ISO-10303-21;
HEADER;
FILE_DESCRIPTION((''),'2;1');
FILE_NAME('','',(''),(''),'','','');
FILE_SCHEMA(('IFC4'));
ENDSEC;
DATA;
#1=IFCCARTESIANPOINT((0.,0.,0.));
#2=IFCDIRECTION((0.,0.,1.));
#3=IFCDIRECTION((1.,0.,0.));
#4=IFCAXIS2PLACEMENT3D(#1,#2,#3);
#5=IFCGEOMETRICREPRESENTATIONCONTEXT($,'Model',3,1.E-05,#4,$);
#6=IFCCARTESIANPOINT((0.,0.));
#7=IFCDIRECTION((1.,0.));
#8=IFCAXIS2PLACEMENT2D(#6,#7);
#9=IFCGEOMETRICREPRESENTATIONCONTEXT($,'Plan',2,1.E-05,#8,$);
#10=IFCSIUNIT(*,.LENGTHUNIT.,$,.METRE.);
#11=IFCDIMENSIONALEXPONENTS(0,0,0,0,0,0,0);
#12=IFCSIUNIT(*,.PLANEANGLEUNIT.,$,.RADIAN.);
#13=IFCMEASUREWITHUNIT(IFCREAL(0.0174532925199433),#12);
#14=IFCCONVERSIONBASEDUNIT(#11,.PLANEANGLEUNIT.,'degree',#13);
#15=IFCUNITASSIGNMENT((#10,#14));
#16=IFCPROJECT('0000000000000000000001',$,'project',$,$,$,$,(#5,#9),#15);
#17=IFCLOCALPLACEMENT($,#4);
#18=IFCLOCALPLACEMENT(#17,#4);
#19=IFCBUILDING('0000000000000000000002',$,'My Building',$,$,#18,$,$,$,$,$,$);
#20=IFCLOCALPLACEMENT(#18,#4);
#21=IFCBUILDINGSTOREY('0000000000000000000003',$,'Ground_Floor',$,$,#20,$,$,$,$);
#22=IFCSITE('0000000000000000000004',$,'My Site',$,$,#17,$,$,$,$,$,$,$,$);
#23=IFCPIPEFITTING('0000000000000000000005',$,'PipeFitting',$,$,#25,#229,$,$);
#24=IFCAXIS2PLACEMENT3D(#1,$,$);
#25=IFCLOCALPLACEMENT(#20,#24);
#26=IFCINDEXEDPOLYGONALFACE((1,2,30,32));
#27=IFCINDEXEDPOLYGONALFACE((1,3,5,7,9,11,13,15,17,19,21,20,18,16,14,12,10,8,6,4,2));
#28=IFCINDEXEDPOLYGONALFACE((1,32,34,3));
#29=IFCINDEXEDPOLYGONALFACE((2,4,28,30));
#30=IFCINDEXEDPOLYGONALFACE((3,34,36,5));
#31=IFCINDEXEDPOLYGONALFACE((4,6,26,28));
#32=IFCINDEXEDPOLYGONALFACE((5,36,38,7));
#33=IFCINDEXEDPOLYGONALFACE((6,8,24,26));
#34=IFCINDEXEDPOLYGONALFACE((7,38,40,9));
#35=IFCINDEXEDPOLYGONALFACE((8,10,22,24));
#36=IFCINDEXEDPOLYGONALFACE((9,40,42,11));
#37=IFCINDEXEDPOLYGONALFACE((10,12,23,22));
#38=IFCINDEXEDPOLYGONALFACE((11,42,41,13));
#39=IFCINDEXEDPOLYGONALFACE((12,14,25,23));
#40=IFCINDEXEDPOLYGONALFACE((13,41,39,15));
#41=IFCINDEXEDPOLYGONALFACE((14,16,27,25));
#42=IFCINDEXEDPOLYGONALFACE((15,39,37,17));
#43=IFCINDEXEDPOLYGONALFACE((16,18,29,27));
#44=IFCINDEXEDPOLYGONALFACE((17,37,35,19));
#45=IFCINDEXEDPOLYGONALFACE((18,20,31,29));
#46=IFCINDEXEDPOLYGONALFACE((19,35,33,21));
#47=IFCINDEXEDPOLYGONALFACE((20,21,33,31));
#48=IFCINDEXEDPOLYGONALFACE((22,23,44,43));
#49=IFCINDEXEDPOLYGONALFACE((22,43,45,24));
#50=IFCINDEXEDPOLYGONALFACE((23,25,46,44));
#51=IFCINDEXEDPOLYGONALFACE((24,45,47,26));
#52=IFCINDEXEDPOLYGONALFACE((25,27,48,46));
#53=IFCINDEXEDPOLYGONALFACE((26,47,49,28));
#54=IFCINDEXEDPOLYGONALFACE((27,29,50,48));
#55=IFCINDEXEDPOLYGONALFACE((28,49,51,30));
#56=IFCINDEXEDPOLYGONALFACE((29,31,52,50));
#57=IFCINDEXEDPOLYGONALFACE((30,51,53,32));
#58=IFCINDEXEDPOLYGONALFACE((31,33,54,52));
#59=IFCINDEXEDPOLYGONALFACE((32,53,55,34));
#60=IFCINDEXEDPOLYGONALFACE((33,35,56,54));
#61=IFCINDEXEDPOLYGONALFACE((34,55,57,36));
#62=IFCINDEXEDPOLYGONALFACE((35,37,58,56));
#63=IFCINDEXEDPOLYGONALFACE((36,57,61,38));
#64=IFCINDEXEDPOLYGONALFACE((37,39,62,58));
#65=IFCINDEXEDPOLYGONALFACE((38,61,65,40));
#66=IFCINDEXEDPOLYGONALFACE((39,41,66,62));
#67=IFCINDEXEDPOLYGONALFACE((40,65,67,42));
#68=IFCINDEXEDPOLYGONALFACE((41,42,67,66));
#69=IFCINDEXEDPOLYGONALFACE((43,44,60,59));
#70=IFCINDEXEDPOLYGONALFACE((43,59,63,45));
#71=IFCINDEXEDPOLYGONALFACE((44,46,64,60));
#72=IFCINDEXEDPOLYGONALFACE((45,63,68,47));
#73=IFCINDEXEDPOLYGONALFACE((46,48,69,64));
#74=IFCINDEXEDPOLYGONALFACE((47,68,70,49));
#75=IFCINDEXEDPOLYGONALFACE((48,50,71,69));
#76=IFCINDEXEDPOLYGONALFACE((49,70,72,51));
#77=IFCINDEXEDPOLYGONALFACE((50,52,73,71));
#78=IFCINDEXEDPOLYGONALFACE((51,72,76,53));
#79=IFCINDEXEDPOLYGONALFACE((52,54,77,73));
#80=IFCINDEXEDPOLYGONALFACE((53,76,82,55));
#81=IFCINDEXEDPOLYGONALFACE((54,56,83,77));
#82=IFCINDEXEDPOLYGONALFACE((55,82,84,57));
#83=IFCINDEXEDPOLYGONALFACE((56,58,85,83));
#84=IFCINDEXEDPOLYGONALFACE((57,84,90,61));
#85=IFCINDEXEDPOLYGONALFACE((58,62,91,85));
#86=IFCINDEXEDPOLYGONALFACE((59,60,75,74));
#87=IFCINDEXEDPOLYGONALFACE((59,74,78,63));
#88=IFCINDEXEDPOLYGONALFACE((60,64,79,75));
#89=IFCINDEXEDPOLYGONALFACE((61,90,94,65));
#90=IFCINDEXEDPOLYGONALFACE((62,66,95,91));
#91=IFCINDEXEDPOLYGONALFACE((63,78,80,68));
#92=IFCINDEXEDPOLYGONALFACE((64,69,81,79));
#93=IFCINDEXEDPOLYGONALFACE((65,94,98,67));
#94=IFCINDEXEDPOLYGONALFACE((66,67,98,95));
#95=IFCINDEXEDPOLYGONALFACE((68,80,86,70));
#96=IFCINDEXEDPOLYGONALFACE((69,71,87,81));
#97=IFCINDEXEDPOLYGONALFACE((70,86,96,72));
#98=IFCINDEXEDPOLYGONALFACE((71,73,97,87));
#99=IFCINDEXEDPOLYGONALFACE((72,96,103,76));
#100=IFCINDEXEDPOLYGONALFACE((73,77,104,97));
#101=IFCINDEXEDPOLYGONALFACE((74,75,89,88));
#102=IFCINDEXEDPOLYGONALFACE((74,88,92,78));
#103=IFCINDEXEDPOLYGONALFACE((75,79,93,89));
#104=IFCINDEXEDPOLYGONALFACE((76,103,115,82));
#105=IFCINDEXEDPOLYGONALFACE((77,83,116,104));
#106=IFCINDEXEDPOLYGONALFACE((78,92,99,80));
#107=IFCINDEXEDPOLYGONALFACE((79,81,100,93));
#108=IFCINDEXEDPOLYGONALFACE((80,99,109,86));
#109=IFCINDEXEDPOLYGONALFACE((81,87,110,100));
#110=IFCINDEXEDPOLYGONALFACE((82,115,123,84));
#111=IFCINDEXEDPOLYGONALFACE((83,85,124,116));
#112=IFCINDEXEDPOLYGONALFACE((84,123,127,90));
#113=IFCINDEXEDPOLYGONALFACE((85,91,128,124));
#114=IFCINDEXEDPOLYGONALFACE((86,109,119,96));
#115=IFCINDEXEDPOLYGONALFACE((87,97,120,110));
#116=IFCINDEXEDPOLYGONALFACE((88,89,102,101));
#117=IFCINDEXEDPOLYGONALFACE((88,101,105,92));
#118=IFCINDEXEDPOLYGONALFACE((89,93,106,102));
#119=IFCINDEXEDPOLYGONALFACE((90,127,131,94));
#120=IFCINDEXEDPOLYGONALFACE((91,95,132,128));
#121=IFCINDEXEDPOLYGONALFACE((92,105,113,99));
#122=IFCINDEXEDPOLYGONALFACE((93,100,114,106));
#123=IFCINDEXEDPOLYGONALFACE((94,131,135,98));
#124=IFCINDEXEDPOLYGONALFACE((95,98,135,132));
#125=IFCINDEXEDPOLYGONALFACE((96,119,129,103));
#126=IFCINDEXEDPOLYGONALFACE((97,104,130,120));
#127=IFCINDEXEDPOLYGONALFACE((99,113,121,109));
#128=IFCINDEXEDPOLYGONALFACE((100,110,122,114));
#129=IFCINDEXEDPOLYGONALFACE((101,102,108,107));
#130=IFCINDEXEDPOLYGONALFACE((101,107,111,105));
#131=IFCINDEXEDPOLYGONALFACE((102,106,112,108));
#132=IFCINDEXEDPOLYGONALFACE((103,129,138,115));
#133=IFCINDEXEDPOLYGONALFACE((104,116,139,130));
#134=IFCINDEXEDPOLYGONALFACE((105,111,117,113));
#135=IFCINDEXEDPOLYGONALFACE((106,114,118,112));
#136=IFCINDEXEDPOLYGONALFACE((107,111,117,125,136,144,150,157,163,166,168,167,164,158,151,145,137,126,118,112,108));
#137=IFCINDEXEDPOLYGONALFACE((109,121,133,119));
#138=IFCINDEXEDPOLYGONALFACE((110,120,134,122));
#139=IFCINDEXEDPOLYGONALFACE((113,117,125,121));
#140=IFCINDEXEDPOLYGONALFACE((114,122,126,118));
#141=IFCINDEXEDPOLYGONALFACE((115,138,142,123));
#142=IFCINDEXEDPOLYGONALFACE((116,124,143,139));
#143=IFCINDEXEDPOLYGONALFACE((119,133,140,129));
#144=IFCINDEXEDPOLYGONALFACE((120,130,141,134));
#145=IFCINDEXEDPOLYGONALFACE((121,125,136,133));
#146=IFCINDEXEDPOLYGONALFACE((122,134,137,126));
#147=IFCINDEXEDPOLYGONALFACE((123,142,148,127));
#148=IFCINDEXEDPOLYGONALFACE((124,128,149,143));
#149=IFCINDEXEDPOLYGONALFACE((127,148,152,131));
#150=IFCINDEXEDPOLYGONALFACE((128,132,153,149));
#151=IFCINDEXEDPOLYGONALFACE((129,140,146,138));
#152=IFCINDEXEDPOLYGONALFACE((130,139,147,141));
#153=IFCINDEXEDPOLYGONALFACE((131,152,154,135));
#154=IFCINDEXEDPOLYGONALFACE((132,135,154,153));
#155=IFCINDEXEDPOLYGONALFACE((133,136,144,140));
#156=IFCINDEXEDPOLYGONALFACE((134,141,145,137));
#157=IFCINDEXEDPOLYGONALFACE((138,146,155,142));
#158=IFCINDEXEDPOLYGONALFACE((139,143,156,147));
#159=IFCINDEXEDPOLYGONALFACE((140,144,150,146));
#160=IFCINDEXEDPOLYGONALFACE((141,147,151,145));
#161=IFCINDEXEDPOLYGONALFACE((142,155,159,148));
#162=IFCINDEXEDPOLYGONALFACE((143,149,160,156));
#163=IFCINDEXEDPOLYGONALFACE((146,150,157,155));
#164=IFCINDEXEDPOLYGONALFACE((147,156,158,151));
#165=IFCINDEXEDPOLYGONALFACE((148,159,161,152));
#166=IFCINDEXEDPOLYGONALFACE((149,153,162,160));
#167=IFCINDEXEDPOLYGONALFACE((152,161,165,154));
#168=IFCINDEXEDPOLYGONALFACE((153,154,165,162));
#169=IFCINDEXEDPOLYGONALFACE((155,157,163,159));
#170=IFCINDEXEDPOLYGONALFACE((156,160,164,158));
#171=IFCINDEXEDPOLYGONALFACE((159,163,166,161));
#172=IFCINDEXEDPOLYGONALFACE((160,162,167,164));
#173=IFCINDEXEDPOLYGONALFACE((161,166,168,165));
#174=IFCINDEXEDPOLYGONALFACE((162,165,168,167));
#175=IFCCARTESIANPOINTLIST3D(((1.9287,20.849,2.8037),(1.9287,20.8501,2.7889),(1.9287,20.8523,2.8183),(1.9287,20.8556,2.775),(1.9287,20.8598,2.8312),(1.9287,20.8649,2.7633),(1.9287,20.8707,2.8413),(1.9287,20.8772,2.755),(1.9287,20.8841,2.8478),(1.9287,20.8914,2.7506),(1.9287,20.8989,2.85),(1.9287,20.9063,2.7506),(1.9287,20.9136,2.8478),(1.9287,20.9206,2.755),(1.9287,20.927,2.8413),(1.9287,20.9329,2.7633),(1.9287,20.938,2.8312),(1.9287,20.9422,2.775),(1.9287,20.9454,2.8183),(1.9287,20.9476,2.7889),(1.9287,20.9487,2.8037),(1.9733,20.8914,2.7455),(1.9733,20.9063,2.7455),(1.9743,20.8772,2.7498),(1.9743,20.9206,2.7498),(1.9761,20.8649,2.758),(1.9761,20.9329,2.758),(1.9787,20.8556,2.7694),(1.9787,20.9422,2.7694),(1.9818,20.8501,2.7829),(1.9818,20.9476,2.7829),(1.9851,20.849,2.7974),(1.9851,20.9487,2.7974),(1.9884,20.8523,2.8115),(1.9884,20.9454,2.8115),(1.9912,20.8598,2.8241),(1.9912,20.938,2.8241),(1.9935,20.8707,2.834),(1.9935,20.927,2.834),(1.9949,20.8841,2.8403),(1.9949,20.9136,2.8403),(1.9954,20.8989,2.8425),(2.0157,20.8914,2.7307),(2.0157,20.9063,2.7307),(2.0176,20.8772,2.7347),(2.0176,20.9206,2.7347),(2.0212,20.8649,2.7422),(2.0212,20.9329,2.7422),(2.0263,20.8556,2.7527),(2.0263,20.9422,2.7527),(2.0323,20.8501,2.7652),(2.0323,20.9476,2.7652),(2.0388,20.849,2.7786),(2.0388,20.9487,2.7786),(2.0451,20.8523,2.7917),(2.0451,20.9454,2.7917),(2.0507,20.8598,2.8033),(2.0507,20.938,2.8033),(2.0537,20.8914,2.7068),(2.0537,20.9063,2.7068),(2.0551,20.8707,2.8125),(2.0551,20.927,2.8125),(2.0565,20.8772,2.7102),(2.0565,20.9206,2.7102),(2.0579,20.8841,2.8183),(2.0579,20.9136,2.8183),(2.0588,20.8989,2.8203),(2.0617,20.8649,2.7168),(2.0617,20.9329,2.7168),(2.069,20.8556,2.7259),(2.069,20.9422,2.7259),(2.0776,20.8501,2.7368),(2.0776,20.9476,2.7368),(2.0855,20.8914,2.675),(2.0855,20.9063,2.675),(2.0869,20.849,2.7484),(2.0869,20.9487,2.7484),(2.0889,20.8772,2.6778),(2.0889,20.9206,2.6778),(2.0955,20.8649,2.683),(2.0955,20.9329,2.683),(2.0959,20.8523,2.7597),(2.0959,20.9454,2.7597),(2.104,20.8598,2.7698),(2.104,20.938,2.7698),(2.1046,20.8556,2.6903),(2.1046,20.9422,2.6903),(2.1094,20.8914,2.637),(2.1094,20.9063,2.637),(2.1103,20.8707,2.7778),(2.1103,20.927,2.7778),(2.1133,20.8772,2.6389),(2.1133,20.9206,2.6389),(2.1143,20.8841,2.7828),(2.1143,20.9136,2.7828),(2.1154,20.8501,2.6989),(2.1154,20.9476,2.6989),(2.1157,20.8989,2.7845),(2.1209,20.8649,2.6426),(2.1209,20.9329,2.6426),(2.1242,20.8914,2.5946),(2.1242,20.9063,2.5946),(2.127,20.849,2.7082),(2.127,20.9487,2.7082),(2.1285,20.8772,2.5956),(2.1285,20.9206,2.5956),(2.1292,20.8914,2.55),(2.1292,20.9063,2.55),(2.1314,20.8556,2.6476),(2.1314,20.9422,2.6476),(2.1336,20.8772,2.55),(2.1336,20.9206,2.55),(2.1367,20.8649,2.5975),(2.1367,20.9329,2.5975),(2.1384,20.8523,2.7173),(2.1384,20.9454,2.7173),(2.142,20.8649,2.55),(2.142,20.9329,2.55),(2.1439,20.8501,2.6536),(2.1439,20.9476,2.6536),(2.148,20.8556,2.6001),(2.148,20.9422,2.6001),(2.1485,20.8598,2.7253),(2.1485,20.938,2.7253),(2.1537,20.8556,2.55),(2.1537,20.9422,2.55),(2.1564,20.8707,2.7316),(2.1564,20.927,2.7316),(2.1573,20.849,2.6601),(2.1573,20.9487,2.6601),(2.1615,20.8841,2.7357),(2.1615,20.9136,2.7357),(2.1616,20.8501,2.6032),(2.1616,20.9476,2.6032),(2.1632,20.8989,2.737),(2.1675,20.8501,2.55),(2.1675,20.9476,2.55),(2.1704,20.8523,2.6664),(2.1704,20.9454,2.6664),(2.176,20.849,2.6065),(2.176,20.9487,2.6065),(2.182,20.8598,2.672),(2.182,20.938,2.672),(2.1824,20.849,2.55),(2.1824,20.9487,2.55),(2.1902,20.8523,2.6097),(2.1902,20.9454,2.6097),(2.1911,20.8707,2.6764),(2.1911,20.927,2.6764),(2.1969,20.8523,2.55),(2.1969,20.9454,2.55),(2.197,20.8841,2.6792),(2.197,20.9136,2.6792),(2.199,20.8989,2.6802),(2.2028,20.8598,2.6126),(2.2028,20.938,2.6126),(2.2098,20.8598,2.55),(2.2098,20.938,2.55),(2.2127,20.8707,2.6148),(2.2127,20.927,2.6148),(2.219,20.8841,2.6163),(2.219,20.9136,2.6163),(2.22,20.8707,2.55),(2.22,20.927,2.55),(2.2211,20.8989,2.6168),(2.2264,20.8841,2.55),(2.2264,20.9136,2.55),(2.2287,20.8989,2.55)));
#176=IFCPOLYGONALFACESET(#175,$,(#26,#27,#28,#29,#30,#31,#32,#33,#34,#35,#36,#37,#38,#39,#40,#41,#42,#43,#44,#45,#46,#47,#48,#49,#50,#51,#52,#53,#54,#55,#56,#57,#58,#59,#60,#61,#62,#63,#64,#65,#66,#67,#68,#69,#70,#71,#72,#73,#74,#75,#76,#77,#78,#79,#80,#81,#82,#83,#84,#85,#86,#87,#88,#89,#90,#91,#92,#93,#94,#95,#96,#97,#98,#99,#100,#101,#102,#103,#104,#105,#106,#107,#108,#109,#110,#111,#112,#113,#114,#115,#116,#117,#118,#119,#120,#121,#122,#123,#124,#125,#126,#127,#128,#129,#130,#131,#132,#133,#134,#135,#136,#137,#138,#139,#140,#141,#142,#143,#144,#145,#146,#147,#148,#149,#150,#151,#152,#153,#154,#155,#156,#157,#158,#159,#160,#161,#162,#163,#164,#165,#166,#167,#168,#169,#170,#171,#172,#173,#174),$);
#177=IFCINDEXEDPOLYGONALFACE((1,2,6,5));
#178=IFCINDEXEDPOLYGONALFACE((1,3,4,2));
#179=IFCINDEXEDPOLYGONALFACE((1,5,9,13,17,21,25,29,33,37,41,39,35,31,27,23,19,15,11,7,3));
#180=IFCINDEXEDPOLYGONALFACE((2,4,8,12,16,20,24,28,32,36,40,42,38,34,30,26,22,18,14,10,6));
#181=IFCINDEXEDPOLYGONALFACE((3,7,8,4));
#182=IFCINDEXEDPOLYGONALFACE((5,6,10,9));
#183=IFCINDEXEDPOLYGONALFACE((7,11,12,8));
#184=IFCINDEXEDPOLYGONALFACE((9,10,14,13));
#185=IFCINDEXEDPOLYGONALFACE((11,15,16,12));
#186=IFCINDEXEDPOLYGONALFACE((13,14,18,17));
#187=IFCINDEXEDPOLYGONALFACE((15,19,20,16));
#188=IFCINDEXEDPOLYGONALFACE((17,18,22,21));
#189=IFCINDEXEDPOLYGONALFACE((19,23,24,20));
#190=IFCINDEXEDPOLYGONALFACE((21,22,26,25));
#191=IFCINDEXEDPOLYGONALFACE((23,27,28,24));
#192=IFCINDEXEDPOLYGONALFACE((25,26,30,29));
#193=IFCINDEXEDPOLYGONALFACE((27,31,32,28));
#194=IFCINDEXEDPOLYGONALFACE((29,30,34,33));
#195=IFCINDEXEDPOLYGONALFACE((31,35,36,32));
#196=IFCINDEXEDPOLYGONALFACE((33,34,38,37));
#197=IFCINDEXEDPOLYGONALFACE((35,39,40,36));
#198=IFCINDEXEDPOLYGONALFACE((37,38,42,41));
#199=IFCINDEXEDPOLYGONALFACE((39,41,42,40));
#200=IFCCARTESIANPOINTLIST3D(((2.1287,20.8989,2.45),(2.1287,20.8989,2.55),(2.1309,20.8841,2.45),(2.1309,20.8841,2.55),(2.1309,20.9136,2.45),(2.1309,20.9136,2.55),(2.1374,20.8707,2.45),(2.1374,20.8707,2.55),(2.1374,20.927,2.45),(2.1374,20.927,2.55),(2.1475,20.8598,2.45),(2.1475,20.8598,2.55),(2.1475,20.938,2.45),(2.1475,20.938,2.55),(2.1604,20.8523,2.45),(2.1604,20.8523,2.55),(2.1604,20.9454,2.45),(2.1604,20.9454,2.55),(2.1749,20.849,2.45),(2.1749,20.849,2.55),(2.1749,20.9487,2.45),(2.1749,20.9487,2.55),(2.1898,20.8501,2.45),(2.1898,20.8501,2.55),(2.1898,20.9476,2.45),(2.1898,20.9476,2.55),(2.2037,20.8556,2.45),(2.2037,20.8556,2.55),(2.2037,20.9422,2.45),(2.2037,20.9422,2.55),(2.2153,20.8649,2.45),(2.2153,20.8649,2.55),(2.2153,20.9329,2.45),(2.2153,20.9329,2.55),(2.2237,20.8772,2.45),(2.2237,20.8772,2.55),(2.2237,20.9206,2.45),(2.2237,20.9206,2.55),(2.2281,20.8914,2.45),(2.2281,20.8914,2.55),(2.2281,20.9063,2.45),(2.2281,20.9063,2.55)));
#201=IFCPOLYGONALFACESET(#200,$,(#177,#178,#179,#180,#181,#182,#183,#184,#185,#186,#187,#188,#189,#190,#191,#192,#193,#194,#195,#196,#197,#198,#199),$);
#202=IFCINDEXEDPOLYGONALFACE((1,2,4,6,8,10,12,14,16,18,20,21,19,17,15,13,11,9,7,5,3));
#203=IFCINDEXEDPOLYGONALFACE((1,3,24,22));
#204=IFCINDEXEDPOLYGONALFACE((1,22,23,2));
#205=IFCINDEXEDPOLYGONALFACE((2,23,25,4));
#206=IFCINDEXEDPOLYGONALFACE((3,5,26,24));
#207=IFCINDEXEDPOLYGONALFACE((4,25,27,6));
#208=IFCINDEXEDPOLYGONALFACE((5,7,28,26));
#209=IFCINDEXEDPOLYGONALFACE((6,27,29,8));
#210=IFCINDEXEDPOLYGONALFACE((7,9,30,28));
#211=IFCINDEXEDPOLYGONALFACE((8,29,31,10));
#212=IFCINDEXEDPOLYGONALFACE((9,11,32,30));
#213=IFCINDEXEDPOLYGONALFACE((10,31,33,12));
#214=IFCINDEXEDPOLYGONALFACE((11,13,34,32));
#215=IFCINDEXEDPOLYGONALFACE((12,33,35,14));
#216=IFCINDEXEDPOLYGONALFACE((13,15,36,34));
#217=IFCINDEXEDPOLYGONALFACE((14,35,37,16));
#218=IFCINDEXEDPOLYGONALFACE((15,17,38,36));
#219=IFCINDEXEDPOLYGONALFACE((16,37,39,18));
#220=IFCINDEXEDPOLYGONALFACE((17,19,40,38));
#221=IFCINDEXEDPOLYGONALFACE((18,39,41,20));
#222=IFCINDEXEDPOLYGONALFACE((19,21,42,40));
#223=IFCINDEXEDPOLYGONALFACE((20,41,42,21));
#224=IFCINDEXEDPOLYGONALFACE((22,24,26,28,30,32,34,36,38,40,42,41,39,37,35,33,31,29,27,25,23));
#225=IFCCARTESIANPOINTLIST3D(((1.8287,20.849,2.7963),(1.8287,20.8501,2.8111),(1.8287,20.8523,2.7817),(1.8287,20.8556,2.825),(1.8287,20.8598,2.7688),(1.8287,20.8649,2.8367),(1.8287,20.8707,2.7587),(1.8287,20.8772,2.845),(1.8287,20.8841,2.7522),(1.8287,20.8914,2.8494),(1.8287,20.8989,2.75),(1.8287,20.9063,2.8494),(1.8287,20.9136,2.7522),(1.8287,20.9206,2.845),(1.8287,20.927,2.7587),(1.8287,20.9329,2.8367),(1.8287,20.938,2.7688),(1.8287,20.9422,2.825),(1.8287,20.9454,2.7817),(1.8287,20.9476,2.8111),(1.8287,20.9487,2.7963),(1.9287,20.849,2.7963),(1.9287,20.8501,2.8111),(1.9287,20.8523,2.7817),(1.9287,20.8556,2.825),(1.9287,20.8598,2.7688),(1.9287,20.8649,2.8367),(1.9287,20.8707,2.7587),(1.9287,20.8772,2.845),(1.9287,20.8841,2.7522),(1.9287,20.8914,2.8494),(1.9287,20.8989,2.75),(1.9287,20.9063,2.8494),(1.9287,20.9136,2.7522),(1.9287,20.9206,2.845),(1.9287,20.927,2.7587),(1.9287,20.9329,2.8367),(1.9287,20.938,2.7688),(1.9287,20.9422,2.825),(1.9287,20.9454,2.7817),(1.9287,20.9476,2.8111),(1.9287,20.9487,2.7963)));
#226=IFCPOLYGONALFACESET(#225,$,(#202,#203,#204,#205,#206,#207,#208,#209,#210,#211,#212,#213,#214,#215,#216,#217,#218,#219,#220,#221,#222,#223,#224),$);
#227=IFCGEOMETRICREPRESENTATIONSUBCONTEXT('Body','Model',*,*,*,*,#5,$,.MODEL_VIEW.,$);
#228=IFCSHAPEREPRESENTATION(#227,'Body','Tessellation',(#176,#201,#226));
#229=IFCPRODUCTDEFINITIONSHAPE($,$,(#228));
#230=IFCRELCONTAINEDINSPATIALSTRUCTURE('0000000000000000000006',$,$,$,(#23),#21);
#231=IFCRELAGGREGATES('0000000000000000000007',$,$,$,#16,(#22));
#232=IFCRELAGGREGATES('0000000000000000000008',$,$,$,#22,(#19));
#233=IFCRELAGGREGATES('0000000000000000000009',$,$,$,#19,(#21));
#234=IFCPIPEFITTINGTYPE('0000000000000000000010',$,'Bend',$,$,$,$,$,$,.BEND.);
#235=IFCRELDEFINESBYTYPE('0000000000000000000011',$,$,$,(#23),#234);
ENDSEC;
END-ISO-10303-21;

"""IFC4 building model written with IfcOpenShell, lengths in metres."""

from ifc_helpers import new_model, entity, si_unit, converted_unit, frame, origin_with_axes, origin_2d_with_axis, place, context, subcontext, project, spatial, circle, extrude, source, transform, mapped, type_object, type_shapes, element, save


model = new_model("IFC4")

# Units and contexts
model_context = context("Model", 3, precision=1e-05, world=origin_with_axes())
plan_context = context("Plan", 2, precision=1e-05, world=origin_2d_with_axis())
body_context = subcontext(model_context, "Body", "Model", "MODEL_VIEW")
ifc_project = project(units=[si_unit("LENGTHUNIT", "METRE"), converted_unit("PLANEANGLEUNIT", "degree", entity("IfcReal", 0.0174532925199433), si_unit("PLANEANGLEUNIT", "RADIAN"), dimensions=[0, 0, 0, 0, 0, 0, 0])], contexts=[model_context, plan_context])

# Site, building, storey
site_placement = place(None, origin_with_axes())
site = spatial("IfcSite", under=ifc_project, at=site_placement, Name="My Site")
building_placement = place(site_placement, origin_with_axes())
building = spatial("IfcBuilding", under=site, at=building_placement, Name="My Building")
storey_placement = place(building_placement, origin_with_axes())
storey = spatial("IfcBuildingStorey", under=building, at=storey_placement, Name="Ground_Floor")

# Pipe fitting
pipe_fitting_type = type_object("IfcPipeFittingType", Name="Bend", PredefinedType="BEND")
shared_shape = source(origin_with_axes(), body_context, "Body", "SolidModel", [
    entity("IfcSweptDiskSolid", entity("IfcIndexedPolyCurve", entity("IfcCartesianPointList3D", [[0.0, 0.0, -0.1], [0.0732, 0.0, -0.2768], [0.25, 0.0, -0.35]]), [entity("IfcArcIndex", [1, 2, 3])]), 0.05),
    extrude(circle(Radius=0.05), origin_with_axes(), (0.0, 0.0, -1.0), 0.1),
    extrude(circle(Radius=0.05), frame((0.25, 0.0, -0.35), z_axis=(1.0, 0.0, 0.0), x_axis=(0.0, 0.0, 1.0)), (0.0, 0.0, 1.0), 0.1),
])
type_shapes(pipe_fitting_type, [shared_shape])
for number, where, z_axis, x_axis, name in (
    (1, (2.1787, 20.8989, 2.45), (0.0, 0.0, -1.0), (-1.0, 0.0, 0.0), "PipeFitting"),
):
    element("IfcPipeFitting", number, at=place(storey_placement, frame(where, z_axis=z_axis, x_axis=x_axis)), inside=storey, type_object=pipe_fitting_type, Name=name, context=body_context, shape_type="MappedRepresentation", body=[
        mapped(shared_shape, transform((0.0, 0.0, 0.0), x_axis=(1.0, 0.0, 0.0), y_axis=(0.0, 1.0, 0.0), z_axis=(0.0, 0.0, 1.0), scale=1.0)),
    ])

save(model, "model.ifc")
